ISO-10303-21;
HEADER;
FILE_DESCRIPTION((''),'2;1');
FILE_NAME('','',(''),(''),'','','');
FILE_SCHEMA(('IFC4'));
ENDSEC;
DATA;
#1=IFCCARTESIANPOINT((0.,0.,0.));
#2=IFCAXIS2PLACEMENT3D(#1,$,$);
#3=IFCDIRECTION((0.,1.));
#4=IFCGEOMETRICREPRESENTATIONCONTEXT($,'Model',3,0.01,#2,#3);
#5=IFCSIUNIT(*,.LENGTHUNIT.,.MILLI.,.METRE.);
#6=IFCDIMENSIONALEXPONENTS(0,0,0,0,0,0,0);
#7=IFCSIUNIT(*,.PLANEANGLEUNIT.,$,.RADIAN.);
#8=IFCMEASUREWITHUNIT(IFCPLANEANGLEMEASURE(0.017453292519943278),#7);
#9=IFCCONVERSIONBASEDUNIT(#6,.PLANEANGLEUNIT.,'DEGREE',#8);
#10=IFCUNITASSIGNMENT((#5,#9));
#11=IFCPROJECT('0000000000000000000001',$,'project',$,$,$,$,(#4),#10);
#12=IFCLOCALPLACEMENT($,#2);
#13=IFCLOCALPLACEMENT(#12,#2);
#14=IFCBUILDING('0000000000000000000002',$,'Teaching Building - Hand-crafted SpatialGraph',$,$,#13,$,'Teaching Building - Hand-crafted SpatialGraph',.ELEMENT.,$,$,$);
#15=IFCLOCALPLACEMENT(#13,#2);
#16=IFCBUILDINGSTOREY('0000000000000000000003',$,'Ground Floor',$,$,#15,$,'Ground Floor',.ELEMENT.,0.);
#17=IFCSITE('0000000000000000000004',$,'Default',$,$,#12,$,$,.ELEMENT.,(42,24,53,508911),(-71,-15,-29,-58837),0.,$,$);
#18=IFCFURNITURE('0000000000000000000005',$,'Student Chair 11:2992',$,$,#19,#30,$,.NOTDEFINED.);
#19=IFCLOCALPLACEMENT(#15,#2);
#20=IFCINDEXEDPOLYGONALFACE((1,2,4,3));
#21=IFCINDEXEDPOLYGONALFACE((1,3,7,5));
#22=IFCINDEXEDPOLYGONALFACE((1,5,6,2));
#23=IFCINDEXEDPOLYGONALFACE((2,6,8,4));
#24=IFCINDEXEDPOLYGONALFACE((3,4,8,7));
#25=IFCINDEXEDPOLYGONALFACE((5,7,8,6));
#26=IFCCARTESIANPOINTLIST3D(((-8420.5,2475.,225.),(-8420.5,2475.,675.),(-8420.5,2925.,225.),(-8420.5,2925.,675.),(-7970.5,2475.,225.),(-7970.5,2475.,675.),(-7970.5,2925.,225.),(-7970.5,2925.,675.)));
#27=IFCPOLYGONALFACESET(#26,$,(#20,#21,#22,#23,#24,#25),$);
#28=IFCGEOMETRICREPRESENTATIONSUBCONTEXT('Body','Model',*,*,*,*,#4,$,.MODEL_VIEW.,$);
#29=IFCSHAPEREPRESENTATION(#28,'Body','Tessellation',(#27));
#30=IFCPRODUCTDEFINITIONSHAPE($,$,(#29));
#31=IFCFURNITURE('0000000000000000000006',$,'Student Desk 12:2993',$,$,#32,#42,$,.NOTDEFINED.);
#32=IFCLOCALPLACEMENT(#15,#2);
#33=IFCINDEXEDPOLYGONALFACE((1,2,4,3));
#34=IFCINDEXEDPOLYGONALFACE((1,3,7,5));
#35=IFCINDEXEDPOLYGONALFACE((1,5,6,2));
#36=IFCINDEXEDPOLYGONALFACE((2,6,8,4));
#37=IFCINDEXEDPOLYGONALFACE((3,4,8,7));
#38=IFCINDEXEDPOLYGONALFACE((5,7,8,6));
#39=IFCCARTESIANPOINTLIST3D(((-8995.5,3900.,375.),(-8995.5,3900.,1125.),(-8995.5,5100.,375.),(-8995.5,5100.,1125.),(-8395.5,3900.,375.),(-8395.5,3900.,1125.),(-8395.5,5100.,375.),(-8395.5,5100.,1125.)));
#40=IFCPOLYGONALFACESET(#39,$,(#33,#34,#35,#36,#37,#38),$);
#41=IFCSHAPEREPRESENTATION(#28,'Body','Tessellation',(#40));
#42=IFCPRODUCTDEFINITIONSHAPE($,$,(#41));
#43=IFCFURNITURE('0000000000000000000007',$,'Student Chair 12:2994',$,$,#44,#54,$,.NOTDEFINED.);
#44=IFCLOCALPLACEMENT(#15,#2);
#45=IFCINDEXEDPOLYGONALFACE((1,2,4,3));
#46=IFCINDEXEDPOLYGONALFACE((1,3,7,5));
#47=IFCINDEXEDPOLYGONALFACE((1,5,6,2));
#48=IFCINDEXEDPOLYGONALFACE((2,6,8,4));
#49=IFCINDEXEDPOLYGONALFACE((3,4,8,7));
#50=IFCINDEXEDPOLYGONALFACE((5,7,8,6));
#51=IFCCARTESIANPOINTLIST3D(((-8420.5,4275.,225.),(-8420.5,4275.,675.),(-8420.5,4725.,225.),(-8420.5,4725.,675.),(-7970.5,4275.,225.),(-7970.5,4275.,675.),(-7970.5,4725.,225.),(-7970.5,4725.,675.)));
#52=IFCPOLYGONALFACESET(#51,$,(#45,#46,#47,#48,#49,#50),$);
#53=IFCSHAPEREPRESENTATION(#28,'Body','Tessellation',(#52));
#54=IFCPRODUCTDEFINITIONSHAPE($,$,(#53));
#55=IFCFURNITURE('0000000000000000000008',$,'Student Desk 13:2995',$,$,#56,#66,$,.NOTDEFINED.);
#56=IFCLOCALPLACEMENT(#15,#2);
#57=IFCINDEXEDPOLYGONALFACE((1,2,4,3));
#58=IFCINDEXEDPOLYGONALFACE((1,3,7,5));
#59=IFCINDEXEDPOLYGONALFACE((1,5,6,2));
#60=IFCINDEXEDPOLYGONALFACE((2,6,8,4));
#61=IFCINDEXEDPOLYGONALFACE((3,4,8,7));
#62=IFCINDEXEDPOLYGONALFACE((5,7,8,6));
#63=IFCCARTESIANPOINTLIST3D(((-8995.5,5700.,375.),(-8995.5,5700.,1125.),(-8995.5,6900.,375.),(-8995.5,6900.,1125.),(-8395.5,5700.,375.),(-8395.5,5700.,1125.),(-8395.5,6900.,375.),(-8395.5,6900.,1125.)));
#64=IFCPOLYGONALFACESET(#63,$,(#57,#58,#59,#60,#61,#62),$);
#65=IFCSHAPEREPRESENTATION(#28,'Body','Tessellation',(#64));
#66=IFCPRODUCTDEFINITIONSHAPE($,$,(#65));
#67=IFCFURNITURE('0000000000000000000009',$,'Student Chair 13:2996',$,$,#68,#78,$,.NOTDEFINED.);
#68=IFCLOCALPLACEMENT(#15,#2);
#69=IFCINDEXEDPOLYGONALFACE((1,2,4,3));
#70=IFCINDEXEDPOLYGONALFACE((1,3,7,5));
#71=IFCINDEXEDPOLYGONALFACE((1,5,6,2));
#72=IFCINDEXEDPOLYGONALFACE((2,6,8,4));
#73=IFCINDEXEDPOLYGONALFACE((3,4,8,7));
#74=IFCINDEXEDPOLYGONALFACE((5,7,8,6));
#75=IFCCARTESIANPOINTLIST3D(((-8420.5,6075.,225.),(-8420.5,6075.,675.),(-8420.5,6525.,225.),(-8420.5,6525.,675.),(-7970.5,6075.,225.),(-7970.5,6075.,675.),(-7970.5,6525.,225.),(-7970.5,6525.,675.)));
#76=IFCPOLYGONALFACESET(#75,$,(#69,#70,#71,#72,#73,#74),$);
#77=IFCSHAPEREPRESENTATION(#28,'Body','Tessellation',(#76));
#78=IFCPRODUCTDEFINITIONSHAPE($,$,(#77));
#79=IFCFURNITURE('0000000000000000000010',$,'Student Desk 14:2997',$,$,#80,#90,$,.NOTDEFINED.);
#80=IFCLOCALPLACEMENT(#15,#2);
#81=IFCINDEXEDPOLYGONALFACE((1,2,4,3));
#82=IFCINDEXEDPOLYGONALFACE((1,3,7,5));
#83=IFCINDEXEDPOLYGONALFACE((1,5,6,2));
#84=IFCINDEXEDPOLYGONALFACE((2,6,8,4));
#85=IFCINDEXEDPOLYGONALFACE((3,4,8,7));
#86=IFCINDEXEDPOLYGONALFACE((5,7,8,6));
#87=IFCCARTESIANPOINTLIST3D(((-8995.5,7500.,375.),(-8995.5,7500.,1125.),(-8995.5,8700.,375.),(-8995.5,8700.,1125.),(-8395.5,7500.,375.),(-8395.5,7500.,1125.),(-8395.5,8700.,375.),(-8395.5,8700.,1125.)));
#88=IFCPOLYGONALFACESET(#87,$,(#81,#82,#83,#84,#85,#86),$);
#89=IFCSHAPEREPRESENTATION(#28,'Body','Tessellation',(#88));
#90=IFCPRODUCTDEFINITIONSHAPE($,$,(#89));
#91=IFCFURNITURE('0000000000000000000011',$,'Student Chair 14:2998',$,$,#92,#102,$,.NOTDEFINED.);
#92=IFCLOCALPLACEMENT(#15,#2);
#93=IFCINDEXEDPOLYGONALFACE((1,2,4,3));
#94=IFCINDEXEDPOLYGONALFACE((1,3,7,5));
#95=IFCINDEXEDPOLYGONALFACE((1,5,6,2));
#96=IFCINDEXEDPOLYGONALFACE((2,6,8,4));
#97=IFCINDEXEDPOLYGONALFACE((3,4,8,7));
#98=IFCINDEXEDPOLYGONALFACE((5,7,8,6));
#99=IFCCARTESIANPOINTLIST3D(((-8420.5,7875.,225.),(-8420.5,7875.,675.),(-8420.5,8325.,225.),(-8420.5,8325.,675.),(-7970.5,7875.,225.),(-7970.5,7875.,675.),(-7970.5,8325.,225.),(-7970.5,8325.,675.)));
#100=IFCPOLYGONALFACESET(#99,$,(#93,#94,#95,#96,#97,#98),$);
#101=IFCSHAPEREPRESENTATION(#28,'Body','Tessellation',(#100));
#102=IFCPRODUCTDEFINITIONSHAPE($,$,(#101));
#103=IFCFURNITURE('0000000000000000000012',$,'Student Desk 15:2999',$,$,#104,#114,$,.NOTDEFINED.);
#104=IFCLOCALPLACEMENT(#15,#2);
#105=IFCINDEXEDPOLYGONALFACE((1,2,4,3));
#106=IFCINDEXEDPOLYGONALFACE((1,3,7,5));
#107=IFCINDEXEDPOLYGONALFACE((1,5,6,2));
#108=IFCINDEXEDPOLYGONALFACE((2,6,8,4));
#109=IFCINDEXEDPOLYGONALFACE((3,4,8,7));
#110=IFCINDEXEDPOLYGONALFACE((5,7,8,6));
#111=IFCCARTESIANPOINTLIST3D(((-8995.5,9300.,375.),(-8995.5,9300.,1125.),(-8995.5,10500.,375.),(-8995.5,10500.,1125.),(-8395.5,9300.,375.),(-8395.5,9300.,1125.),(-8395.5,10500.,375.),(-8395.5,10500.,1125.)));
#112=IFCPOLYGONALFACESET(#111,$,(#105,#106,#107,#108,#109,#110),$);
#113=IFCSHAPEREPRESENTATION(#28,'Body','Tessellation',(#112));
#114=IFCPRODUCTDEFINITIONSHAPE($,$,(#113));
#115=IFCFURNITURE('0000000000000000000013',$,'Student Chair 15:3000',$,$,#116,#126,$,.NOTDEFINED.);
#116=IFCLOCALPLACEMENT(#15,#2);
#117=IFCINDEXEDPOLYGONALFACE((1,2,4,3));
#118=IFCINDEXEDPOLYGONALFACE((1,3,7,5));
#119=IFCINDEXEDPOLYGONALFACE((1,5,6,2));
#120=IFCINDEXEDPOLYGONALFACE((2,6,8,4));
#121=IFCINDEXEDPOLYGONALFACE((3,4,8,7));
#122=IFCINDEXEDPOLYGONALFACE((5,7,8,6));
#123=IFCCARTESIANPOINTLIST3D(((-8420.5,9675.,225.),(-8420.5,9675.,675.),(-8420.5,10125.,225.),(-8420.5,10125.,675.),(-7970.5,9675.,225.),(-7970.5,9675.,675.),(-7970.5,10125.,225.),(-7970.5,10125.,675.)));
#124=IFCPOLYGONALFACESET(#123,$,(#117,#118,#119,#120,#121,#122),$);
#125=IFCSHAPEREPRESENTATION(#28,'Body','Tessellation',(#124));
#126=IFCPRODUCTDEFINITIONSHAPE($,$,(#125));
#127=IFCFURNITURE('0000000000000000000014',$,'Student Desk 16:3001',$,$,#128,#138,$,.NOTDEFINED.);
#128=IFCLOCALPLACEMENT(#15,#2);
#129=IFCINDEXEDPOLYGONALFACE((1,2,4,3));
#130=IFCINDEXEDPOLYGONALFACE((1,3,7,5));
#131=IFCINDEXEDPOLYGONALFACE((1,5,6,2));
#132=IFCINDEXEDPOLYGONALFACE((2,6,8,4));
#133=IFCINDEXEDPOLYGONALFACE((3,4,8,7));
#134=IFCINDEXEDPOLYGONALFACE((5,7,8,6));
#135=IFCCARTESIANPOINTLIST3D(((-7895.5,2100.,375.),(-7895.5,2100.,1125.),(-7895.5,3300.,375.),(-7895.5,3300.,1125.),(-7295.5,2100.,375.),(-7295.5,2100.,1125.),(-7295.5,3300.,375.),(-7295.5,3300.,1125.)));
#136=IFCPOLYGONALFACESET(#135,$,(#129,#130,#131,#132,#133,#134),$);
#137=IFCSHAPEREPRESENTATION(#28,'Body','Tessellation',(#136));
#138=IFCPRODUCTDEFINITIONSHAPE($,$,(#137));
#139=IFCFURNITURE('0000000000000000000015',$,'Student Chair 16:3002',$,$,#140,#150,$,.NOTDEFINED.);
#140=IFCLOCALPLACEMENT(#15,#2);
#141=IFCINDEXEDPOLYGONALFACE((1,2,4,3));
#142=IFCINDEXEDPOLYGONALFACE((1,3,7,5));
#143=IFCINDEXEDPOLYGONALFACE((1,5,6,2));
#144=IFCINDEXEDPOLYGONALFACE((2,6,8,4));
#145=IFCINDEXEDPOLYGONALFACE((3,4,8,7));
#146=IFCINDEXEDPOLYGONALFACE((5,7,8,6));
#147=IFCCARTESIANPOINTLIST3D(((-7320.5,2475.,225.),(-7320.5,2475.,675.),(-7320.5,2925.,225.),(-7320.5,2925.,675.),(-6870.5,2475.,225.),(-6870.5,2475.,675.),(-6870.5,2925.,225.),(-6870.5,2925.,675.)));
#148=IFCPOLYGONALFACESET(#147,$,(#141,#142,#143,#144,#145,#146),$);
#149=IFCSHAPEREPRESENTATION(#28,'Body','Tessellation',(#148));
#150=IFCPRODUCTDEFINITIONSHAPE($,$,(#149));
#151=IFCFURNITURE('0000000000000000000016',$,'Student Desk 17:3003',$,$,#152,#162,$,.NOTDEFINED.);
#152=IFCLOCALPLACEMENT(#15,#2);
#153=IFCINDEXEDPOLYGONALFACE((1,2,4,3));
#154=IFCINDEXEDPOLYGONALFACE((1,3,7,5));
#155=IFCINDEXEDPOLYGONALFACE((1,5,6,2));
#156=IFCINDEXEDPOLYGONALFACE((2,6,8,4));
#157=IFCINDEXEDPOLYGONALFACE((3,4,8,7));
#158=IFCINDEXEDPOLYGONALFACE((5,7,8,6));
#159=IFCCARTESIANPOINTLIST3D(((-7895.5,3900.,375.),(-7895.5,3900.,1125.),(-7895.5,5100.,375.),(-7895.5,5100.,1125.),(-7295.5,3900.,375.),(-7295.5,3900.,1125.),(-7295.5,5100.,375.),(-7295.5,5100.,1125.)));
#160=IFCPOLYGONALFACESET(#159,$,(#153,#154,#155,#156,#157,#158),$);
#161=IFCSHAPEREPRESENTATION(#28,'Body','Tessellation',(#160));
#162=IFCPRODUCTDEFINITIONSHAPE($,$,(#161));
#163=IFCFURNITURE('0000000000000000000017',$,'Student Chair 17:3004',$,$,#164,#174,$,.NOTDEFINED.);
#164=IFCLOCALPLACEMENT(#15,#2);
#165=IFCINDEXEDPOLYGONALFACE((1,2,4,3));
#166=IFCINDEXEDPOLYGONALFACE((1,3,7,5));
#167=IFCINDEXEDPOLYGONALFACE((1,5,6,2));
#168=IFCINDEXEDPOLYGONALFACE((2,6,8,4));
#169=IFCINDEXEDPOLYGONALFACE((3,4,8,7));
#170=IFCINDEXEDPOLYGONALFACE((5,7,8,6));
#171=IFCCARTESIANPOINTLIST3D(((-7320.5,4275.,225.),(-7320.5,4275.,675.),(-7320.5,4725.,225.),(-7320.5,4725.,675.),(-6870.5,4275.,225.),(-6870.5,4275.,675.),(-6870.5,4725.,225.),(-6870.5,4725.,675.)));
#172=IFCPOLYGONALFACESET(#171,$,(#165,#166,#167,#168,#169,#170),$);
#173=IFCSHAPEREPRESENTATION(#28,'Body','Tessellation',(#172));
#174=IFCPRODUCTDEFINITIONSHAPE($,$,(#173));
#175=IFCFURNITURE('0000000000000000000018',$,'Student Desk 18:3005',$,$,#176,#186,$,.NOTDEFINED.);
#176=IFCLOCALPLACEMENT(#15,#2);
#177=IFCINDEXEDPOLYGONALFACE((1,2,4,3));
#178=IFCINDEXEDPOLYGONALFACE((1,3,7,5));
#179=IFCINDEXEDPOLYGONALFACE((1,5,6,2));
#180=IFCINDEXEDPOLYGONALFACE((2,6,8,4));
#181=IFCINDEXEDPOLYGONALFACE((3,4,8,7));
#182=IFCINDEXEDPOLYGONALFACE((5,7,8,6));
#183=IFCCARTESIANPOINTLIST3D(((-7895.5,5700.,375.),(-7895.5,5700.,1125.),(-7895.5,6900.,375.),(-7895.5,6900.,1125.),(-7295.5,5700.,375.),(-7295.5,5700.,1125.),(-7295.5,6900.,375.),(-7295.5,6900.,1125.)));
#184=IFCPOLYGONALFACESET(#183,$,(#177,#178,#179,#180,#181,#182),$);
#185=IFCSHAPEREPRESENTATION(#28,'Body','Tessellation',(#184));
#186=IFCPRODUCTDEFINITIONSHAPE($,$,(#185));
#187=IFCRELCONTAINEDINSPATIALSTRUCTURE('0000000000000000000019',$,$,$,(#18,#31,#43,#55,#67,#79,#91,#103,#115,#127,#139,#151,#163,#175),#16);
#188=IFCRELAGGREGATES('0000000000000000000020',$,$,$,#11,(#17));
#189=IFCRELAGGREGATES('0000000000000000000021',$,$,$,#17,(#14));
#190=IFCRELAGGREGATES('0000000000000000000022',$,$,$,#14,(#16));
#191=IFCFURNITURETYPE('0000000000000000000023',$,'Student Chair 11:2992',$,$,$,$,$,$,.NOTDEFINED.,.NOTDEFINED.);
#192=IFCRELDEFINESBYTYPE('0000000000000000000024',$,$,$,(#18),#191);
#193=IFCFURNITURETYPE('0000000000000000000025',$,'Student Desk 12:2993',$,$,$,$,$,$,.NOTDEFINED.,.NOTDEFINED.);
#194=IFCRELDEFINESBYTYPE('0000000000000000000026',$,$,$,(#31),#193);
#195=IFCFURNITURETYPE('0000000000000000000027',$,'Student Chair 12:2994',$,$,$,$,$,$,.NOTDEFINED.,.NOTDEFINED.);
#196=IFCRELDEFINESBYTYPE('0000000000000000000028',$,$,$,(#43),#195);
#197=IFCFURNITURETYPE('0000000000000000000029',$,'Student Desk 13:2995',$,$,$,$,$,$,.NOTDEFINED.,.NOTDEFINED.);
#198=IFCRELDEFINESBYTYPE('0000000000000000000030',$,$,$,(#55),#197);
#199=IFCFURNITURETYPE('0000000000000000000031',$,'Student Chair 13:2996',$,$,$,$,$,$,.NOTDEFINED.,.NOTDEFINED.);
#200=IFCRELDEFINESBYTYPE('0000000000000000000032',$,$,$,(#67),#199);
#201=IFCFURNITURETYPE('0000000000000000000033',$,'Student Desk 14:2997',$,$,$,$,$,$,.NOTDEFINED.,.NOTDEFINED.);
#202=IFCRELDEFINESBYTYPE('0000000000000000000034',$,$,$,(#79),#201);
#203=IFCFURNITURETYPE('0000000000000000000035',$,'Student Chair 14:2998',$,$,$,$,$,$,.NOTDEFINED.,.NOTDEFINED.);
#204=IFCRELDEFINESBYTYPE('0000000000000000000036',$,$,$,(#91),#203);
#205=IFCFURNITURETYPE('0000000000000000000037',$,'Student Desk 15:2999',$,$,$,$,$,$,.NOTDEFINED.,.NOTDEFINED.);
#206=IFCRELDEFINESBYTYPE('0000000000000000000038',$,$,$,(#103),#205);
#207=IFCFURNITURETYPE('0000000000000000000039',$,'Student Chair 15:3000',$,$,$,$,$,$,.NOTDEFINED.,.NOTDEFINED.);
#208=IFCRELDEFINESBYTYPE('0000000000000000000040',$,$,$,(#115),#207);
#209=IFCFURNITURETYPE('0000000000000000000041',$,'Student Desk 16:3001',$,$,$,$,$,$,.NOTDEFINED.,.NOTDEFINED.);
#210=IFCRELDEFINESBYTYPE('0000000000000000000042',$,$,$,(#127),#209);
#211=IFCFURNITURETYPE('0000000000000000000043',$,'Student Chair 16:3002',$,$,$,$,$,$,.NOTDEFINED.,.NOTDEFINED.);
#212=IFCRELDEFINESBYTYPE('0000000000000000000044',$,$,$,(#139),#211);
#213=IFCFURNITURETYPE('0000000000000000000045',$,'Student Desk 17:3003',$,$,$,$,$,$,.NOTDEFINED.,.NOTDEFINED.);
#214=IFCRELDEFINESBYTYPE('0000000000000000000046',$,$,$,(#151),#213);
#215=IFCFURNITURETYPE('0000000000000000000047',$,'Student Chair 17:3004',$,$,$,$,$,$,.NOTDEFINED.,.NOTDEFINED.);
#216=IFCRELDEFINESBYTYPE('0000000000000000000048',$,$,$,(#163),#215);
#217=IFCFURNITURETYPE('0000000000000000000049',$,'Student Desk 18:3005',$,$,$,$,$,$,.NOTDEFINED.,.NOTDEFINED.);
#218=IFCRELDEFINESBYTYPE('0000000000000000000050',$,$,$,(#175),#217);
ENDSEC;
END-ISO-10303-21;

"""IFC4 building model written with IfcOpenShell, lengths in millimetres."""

from ifc_helpers import new_model, entity, si_unit, converted_unit, direction, frame, frame_2d, origin, origin_2d_with_axis, place, context, subcontext, project, spatial, rectangle, extrude, type_object, element, save


model = new_model("IFC4")

# Units and contexts
model_context = context("Model", 3, precision=0.01, world=origin(), true_north=direction((0.0, 1.0)))
body_context = subcontext(model_context, "Body", "Model", "MODEL_VIEW")
ifc_project = project(units=[si_unit("LENGTHUNIT", "METRE", prefix="MILLI"), converted_unit("PLANEANGLEUNIT", "DEGREE", entity("IfcPlaneAngleMeasure", 0.017453292519943278), si_unit("PLANEANGLEUNIT", "RADIAN"), dimensions=[0, 0, 0, 0, 0, 0, 0])], contexts=[model_context])

# Site, building, storey
site_placement = place(None, origin())
site = spatial("IfcSite", under=ifc_project, at=site_placement, Name="Default", CompositionType="ELEMENT", RefLatitude=(42, 24, 53, 508911), RefLongitude=(-71, -15, -29, -58837), RefElevation=0.0)
building_placement = place(site_placement, origin())
building = spatial("IfcBuilding", under=site, at=building_placement, Name="Teaching Building - Hand-crafted SpatialGraph", LongName="Teaching Building - Hand-crafted SpatialGraph", CompositionType="ELEMENT")
storey_placement = place(building_placement, origin())
storey = spatial("IfcBuildingStorey", under=building, at=storey_placement, Name="Ground Floor", LongName="Ground Floor", CompositionType="ELEMENT", Elevation=0.0)

# Furniture
furniture_type_1 = type_object("IfcFurnitureType", Name="Student Chair 11:2992", PredefinedType="NOTDEFINED")
furniture_1_placement = place(storey_placement, origin())
element("IfcFurniture", 1, at=furniture_1_placement, inside=storey, type_object=furniture_type_1, Name="Student Chair 11:2992", PredefinedType="NOTDEFINED", context=body_context, shape_type="SweptSolid", body=[
    extrude(rectangle(XDim=450.0, YDim=450.0, at=origin_2d_with_axis()), frame((-8195.5, 2700.0, 225.0)), (0.0, 0.0, 1.0), 450.0),
])
furniture_type_2 = type_object("IfcFurnitureType", Name="Student Desk 12:2993", PredefinedType="NOTDEFINED")
furniture_2_placement = place(storey_placement, origin())
element("IfcFurniture", 2, at=furniture_2_placement, inside=storey, type_object=furniture_type_2, Name="Student Desk 12:2993", PredefinedType="NOTDEFINED", context=body_context, shape_type="SweptSolid", body=[
    extrude(rectangle(XDim=1200.0, YDim=600.0, at=frame_2d((0.0, 0.0), x_axis=(1.0, 0.0))), frame((-8695.5, 4500.0, 375.0), z_axis=(0.0, 0.0, 1.0), x_axis=(0.0, 1.0, 0.0)), (0.0, 0.0, 1.0), 750.0),
])
furniture_type_3 = type_object("IfcFurnitureType", Name="Student Chair 12:2994", PredefinedType="NOTDEFINED")
furniture_3_placement = place(storey_placement, origin())
element("IfcFurniture", 3, at=furniture_3_placement, inside=storey, type_object=furniture_type_3, Name="Student Chair 12:2994", PredefinedType="NOTDEFINED", context=body_context, shape_type="SweptSolid", body=[
    extrude(rectangle(XDim=450.0, YDim=450.0, at=origin_2d_with_axis()), frame((-8195.5, 4500.0, 225.0)), (0.0, 0.0, 1.0), 450.0),
])
furniture_type_4 = type_object("IfcFurnitureType", Name="Student Desk 13:2995", PredefinedType="NOTDEFINED")
furniture_4_placement = place(storey_placement, origin())
element("IfcFurniture", 4, at=furniture_4_placement, inside=storey, type_object=furniture_type_4, Name="Student Desk 13:2995", PredefinedType="NOTDEFINED", context=body_context, shape_type="SweptSolid", body=[
    extrude(rectangle(XDim=1200.0, YDim=600.0, at=frame_2d((0.0, 0.0), x_axis=(1.0, 0.0))), frame((-8695.5, 6300.0, 375.0), z_axis=(0.0, 0.0, 1.0), x_axis=(0.0, 1.0, 0.0)), (0.0, 0.0, 1.0), 750.0),
])
furniture_type_5 = type_object("IfcFurnitureType", Name="Student Chair 13:2996", PredefinedType="NOTDEFINED")
furniture_5_placement = place(storey_placement, origin())
element("IfcFurniture", 5, at=furniture_5_placement, inside=storey, type_object=furniture_type_5, Name="Student Chair 13:2996", PredefinedType="NOTDEFINED", context=body_context, shape_type="SweptSolid", body=[
    extrude(rectangle(XDim=450.0, YDim=450.0, at=origin_2d_with_axis()), frame((-8195.5, 6300.0, 225.0)), (0.0, 0.0, 1.0), 450.0),
])
furniture_type_6 = type_object("IfcFurnitureType", Name="Student Desk 14:2997", PredefinedType="NOTDEFINED")
furniture_6_placement = place(storey_placement, origin())
element("IfcFurniture", 6, at=furniture_6_placement, inside=storey, type_object=furniture_type_6, Name="Student Desk 14:2997", PredefinedType="NOTDEFINED", context=body_context, shape_type="SweptSolid", body=[
    extrude(rectangle(XDim=1200.0, YDim=600.0, at=frame_2d((0.0, 0.0), x_axis=(1.0, 0.0))), frame((-8695.5, 8100.0, 375.0), z_axis=(0.0, 0.0, 1.0), x_axis=(0.0, 1.0, 0.0)), (0.0, 0.0, 1.0), 750.0),
])
furniture_type_7 = type_object("IfcFurnitureType", Name="Student Chair 14:2998", PredefinedType="NOTDEFINED")
furniture_7_placement = place(storey_placement, origin())
element("IfcFurniture", 7, at=furniture_7_placement, inside=storey, type_object=furniture_type_7, Name="Student Chair 14:2998", PredefinedType="NOTDEFINED", context=body_context, shape_type="SweptSolid", body=[
    extrude(rectangle(XDim=450.0, YDim=450.0, at=origin_2d_with_axis()), frame((-8195.5, 8100.0, 225.0)), (0.0, 0.0, 1.0), 450.0),
])
furniture_type_8 = type_object("IfcFurnitureType", Name="Student Desk 15:2999", PredefinedType="NOTDEFINED")
furniture_8_placement = place(storey_placement, origin())
element("IfcFurniture", 8, at=furniture_8_placement, inside=storey, type_object=furniture_type_8, Name="Student Desk 15:2999", PredefinedType="NOTDEFINED", context=body_context, shape_type="SweptSolid", body=[
    extrude(rectangle(XDim=1200.0, YDim=600.0, at=frame_2d((0.0, 0.0), x_axis=(1.0, 0.0))), frame((-8695.5, 9900.0, 375.0), z_axis=(0.0, 0.0, 1.0), x_axis=(0.0, 1.0, 0.0)), (0.0, 0.0, 1.0), 750.0),
])
furniture_type_9 = type_object("IfcFurnitureType", Name="Student Chair 15:3000", PredefinedType="NOTDEFINED")
furniture_9_placement = place(storey_placement, origin())
element("IfcFurniture", 9, at=furniture_9_placement, inside=storey, type_object=furniture_type_9, Name="Student Chair 15:3000", PredefinedType="NOTDEFINED", context=body_context, shape_type="SweptSolid", body=[
    extrude(rectangle(XDim=450.0, YDim=450.0, at=frame_2d((0.0, 0.0), x_axis=(1.0, 0.0))), frame((-8195.5, 9900.0, 225.0)), (0.0, 0.0, 1.0), 450.0),
])
furniture_type_10 = type_object("IfcFurnitureType", Name="Student Desk 16:3001", PredefinedType="NOTDEFINED")
furniture_10_placement = place(storey_placement, origin())
element("IfcFurniture", 10, at=furniture_10_placement, inside=storey, type_object=furniture_type_10, Name="Student Desk 16:3001", PredefinedType="NOTDEFINED", context=body_context, shape_type="SweptSolid", body=[
    extrude(rectangle(XDim=1200.0, YDim=600.0, at=origin_2d_with_axis()), frame((-7595.5, 2700.0, 375.0), z_axis=(0.0, 0.0, 1.0), x_axis=(0.0, 1.0, 0.0)), (0.0, 0.0, 1.0), 750.0),
])
furniture_type_11 = type_object("IfcFurnitureType", Name="Student Chair 16:3002", PredefinedType="NOTDEFINED")
furniture_11_placement = place(storey_placement, origin())
element("IfcFurniture", 11, at=furniture_11_placement, inside=storey, type_object=furniture_type_11, Name="Student Chair 16:3002", PredefinedType="NOTDEFINED", context=body_context, shape_type="SweptSolid", body=[
    extrude(rectangle(XDim=450.0, YDim=450.0, at=origin_2d_with_axis()), frame((-7095.5, 2700.0, 225.0)), (0.0, 0.0, 1.0), 450.0),
])
furniture_type_12 = type_object("IfcFurnitureType", Name="Student Desk 17:3003", PredefinedType="NOTDEFINED")
furniture_12_placement = place(storey_placement, origin())
element("IfcFurniture", 12, at=furniture_12_placement, inside=storey, type_object=furniture_type_12, Name="Student Desk 17:3003", PredefinedType="NOTDEFINED", context=body_context, shape_type="SweptSolid", body=[
    extrude(rectangle(XDim=1200.0, YDim=600.0, at=frame_2d((0.0, 0.0), x_axis=(1.0, 0.0))), frame((-7595.5, 4500.0, 375.0), z_axis=(0.0, 0.0, 1.0), x_axis=(0.0, 1.0, 0.0)), (0.0, 0.0, 1.0), 750.0),
])
furniture_type_13 = type_object("IfcFurnitureType", Name="Student Chair 17:3004", PredefinedType="NOTDEFINED")
furniture_13_placement = place(storey_placement, origin())
element("IfcFurniture", 13, at=furniture_13_placement, inside=storey, type_object=furniture_type_13, Name="Student Chair 17:3004", PredefinedType="NOTDEFINED", context=body_context, shape_type="SweptSolid", body=[
    extrude(rectangle(XDim=450.0, YDim=450.0, at=origin_2d_with_axis()), frame((-7095.5, 4500.0, 225.0)), (0.0, 0.0, 1.0), 450.0),
])
furniture_type_14 = type_object("IfcFurnitureType", Name="Student Desk 18:3005", PredefinedType="NOTDEFINED")
furniture_14_placement = place(storey_placement, origin())
element("IfcFurniture", 14, at=furniture_14_placement, inside=storey, type_object=furniture_type_14, Name="Student Desk 18:3005", PredefinedType="NOTDEFINED", context=body_context, shape_type="SweptSolid", body=[
    extrude(rectangle(XDim=1200.0, YDim=600.0, at=origin_2d_with_axis()), frame((-7595.5, 6300.0, 375.0), z_axis=(0.0, 0.0, 1.0), x_axis=(0.0, 1.0, 0.0)), (0.0, 0.0, 1.0), 750.0),
])

save(model, "model.ifc")
